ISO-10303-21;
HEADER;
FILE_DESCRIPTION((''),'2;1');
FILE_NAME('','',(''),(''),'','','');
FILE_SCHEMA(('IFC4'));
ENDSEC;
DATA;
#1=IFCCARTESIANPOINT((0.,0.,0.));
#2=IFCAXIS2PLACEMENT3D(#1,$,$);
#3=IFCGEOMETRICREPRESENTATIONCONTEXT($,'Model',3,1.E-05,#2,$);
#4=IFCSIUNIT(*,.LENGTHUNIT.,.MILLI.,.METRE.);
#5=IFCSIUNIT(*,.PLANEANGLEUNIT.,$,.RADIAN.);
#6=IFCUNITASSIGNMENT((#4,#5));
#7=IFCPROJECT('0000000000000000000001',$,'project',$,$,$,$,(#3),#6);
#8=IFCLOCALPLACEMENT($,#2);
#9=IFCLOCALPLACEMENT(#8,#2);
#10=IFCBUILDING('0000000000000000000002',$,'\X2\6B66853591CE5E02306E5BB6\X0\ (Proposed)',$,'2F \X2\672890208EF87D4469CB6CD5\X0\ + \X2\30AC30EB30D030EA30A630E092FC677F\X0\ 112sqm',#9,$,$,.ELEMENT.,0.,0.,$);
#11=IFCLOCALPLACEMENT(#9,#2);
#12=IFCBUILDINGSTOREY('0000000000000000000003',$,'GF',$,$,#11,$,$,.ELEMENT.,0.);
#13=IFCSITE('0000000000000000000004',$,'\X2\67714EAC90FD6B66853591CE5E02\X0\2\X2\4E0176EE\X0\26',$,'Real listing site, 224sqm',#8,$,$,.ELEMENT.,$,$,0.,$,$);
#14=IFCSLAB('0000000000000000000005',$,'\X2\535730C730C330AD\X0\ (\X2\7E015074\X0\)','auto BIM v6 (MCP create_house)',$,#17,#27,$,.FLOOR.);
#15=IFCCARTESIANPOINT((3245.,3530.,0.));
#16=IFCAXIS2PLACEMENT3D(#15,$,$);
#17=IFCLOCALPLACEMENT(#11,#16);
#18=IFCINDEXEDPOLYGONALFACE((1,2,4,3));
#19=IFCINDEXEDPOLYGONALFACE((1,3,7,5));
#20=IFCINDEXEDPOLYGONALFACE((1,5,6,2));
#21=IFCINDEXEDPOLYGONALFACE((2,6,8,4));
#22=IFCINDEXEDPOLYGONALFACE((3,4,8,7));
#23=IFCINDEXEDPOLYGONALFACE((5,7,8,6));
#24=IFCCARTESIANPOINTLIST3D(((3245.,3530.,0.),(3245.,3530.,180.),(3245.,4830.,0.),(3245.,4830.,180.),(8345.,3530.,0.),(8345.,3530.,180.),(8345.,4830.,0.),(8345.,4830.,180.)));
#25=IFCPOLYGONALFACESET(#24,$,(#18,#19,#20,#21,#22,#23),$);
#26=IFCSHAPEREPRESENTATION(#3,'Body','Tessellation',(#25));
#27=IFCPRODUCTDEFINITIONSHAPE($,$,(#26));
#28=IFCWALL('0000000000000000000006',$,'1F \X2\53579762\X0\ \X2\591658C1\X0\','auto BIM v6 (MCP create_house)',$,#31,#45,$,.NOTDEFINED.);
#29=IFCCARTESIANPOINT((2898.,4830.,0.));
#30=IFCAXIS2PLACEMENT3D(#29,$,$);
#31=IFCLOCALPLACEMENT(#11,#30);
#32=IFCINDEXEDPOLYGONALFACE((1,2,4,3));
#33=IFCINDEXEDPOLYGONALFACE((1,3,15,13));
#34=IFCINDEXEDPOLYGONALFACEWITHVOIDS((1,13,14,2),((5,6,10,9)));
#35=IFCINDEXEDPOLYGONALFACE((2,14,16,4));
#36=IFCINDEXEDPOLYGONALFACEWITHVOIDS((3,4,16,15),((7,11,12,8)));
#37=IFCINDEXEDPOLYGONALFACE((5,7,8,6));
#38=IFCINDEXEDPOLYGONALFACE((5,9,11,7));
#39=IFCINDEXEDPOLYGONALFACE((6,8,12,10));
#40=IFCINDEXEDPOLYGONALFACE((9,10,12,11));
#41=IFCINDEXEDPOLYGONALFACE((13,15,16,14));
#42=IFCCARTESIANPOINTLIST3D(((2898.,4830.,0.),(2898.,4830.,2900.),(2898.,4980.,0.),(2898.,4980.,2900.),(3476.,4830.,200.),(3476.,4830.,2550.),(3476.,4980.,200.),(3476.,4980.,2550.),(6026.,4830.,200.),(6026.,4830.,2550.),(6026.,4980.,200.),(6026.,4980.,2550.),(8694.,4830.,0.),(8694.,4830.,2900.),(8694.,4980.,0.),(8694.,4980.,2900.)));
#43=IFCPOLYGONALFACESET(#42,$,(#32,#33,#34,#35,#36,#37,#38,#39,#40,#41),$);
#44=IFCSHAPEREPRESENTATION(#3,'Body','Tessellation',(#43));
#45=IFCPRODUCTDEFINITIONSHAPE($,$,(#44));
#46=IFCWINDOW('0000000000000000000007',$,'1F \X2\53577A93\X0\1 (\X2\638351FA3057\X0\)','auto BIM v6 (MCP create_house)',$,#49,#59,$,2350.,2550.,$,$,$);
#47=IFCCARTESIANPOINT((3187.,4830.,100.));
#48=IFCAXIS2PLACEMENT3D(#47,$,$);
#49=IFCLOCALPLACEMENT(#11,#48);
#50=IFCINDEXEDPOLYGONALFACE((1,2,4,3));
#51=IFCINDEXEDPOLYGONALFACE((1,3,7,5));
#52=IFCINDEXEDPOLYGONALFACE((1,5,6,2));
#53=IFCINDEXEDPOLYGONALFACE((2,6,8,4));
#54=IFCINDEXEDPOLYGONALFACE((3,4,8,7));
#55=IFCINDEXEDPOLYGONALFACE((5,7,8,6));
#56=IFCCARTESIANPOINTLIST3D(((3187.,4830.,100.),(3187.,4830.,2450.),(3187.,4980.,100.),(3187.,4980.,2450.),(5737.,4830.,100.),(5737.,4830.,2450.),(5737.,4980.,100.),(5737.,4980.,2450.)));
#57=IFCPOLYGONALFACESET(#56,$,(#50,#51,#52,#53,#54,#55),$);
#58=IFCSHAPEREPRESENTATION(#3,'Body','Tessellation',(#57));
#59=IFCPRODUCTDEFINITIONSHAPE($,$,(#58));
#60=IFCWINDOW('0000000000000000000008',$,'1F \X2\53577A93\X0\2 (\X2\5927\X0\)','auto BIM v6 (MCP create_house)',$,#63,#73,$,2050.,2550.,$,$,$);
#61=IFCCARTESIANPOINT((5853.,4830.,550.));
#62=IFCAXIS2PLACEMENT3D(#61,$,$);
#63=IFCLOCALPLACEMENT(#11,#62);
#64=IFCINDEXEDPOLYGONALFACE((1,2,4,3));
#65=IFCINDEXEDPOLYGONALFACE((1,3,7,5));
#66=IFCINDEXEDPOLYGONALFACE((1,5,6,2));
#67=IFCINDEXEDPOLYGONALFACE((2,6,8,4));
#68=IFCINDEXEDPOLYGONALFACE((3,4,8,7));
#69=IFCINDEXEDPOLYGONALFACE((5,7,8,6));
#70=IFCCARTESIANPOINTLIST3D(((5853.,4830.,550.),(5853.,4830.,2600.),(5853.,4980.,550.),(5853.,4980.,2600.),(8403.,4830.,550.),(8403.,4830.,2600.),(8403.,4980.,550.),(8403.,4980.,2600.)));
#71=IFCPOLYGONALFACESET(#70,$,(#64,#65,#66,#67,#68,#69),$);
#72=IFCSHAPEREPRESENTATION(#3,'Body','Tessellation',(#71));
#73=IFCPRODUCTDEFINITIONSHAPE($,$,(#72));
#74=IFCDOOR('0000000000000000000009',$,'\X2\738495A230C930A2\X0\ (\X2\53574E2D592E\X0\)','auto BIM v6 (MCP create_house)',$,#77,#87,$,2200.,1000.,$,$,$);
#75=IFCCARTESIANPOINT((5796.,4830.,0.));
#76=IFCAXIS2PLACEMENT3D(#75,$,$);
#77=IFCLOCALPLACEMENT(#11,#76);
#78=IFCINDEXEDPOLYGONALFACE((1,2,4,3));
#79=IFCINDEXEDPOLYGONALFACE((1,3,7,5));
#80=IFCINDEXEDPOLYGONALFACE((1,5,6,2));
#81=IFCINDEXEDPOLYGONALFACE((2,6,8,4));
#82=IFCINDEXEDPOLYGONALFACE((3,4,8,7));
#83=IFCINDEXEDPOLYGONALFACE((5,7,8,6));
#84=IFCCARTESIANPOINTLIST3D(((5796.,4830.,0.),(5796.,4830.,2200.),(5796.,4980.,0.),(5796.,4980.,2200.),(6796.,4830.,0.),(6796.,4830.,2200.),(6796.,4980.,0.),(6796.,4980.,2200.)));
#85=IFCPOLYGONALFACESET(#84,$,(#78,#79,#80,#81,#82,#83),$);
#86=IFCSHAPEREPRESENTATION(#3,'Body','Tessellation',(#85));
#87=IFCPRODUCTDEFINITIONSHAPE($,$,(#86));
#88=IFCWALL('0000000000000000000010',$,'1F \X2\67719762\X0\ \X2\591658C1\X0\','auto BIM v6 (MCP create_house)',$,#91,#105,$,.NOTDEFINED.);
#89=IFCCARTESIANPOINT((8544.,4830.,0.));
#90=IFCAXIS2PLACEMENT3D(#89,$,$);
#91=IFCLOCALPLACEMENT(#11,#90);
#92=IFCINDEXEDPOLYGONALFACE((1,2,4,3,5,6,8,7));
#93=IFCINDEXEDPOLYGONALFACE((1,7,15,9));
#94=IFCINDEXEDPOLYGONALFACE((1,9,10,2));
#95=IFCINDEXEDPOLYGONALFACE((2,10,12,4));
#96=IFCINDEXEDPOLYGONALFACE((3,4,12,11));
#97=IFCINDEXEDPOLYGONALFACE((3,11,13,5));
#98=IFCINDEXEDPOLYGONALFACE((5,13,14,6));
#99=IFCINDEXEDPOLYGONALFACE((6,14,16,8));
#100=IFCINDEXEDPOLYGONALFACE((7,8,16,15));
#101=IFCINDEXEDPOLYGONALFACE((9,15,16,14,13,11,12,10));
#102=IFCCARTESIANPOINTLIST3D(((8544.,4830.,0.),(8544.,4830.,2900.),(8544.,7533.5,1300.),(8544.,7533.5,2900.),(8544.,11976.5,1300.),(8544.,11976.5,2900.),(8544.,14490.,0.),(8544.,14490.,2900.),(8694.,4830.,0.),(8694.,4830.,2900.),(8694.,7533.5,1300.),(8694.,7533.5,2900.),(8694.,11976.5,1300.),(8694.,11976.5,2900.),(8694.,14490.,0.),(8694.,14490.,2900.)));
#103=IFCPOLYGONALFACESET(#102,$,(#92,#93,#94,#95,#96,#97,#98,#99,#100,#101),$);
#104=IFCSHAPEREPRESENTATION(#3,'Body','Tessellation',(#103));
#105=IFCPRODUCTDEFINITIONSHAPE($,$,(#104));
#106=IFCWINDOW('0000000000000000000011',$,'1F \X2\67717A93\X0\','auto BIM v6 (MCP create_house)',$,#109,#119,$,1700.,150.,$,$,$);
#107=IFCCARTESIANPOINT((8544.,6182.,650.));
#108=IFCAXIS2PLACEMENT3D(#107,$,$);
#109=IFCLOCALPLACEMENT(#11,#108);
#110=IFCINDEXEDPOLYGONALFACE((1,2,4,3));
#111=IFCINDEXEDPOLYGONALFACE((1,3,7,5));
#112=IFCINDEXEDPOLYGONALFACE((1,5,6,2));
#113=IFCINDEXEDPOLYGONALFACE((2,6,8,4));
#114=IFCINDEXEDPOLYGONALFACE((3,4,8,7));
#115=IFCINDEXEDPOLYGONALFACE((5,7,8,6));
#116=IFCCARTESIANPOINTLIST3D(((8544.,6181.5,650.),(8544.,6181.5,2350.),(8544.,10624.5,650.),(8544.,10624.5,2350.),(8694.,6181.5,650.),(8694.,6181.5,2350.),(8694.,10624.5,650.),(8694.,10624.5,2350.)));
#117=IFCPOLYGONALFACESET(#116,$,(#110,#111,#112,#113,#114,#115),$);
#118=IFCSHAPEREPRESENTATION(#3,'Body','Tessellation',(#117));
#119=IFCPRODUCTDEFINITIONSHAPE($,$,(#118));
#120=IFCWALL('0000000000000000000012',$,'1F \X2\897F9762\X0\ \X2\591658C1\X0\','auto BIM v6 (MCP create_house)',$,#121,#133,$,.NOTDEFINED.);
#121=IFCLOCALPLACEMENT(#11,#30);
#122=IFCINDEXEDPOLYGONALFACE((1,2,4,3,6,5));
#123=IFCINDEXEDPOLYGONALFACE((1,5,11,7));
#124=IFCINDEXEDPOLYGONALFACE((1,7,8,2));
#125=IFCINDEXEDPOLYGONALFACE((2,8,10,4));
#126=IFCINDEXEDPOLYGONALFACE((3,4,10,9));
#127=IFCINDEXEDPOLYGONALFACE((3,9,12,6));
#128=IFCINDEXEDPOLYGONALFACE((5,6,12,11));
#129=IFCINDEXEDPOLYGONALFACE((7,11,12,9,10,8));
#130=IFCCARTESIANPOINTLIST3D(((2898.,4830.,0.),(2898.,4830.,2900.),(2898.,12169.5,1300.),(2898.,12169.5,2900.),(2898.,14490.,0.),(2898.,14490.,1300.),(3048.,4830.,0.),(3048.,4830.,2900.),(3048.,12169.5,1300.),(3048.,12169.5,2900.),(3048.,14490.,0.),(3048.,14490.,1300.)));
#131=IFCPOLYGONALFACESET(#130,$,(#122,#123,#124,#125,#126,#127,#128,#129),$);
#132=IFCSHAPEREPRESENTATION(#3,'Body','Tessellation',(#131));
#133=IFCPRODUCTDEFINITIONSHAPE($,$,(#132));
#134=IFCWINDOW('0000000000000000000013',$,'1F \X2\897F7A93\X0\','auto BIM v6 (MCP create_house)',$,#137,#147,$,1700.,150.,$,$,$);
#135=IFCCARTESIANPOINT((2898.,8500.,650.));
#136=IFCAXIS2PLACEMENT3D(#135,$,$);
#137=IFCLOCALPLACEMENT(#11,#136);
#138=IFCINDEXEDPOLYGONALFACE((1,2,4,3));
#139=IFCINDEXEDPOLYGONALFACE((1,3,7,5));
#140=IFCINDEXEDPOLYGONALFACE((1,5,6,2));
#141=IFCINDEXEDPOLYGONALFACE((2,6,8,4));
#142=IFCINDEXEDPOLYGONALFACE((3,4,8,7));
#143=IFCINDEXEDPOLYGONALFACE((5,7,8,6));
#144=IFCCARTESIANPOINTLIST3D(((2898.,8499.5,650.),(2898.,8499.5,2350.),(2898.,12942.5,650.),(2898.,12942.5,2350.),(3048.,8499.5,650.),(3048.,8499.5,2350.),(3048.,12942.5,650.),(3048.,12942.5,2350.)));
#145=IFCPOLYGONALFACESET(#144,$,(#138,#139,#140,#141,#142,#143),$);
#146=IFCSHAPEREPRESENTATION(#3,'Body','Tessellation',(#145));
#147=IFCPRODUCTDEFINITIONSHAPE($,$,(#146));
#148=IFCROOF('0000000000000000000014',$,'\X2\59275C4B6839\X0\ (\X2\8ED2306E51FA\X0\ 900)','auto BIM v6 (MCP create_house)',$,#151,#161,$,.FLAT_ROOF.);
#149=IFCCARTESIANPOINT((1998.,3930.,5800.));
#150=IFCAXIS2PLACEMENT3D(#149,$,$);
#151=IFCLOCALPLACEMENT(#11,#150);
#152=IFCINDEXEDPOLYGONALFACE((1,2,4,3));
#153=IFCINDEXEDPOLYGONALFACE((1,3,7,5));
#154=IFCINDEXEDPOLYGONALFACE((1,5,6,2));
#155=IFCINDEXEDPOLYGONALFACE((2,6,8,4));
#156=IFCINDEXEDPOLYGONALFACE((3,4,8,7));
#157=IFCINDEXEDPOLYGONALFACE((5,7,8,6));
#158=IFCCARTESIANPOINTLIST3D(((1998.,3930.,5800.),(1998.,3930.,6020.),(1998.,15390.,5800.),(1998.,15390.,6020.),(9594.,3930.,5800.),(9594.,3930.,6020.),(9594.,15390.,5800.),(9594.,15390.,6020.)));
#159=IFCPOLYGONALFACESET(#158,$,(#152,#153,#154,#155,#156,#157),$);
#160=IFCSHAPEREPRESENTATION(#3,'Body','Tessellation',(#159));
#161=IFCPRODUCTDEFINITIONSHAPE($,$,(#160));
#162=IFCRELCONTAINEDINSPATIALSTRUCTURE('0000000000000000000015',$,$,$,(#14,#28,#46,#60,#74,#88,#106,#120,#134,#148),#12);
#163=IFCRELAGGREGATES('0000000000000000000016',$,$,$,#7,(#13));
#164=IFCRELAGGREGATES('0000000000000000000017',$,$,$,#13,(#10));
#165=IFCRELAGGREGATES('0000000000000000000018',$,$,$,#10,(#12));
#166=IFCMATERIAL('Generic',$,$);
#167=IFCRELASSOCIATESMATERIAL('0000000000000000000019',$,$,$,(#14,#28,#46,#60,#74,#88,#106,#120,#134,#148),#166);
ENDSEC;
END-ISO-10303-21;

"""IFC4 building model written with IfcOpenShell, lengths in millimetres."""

from ifc_helpers import new_model, si_unit, frame, frame_2d, origin, place, context, project, spatial, rectangle, extrude, material, element, fill, save


model = new_model("IFC4")

# Units and contexts
model_context = context("Model", 3, precision=1e-05, world=origin())
ifc_project = project(units=[si_unit("LENGTHUNIT", "METRE", prefix="MILLI"), si_unit("PLANEANGLEUNIT", "RADIAN")], contexts=[model_context])

# Site, building, storey
site_placement = place(None, origin())
site = spatial("IfcSite", under=ifc_project, at=site_placement, Name="東京都武蔵野市2丁目26", ObjectType="Real listing site, 224sqm", CompositionType="ELEMENT", RefElevation=0.0)
building_placement = place(site_placement, origin())
building = spatial("IfcBuilding", under=site, at=building_placement, Name="武蔵野市の家 (Proposed)", ObjectType="2F 木造軸組構法 + ガルバリウム鋼板 112sqm", CompositionType="ELEMENT", ElevationOfRefHeight=0.0, ElevationOfTerrain=0.0)
storey_placement = place(building_placement, origin())
storey = spatial("IfcBuildingStorey", under=building, at=storey_placement, Name="GF", CompositionType="ELEMENT", Elevation=0.0)

# Slab
ifc_material = material(Name="Generic")
slab_1_placement = place(storey_placement, frame((3245.0, 3530.0, 0.0)))
element("IfcSlab", 1, at=slab_1_placement, inside=storey, material=ifc_material, Name="南デッキ (縁側)", Description="auto BIM v6 (MCP create_house)", PredefinedType="FLOOR", context=model_context, shape_type="SweptSolid", body=[
    extrude(rectangle(XDim=5100.0, YDim=1300.0, at=frame_2d((2550.0, 650.0))), frame((3245.0, 3530.0, 0.0)), (0.0, 0.0, 1.0), 180.0),
])

# Wall, openings, windows, door
wall_1_placement = place(storey_placement, frame((2898.0, 4830.0, 0.0)))
wall_1 = element("IfcWall", 2, at=wall_1_placement, inside=storey, material=ifc_material, Name="1F 南面 外壁", Description="auto BIM v6 (MCP create_house)", PredefinedType="NOTDEFINED", context=model_context, shape_type="SweptSolid", body=[
    extrude(rectangle(XDim=5796.0, YDim=150.0, at=frame_2d((2898.0, 75.0))), frame((2898.0, 4830.0, 0.0)), (0.0, 0.0, 1.0), 2900.0),
])
opening_1_placement = place(storey_placement, frame((3187.0, 4830.0, 100.0)))
opening_1 = element("IfcOpeningElement", 3, at=opening_1_placement, cuts=wall_1, PredefinedType="NOTDEFINED", context=model_context, shape_type="SweptSolid", body=[
    extrude(rectangle(XDim=2550.0, YDim=150.0, at=frame_2d((1275.0, 75.0))), frame((3187.0, 4830.0, 100.0)), (0.0, 0.0, 1.0), 2350.0),
])
opening_2_placement = place(storey_placement, frame((5853.0, 4830.0, 550.0)))
opening_2 = element("IfcOpeningElement", 4, at=opening_2_placement, cuts=wall_1, PredefinedType="NOTDEFINED", context=model_context, shape_type="SweptSolid", body=[
    extrude(rectangle(XDim=2550.0, YDim=150.0, at=frame_2d((1275.0, 75.0))), frame((5853.0, 4830.0, 550.0)), (0.0, 0.0, 1.0), 2050.0),
])
opening_3_placement = place(storey_placement, frame((5796.0, 4830.0, 0.0)))
opening_3 = element("IfcOpeningElement", 5, at=opening_3_placement, cuts=wall_1, PredefinedType="NOTDEFINED", context=model_context, shape_type="SweptSolid", body=[
    extrude(rectangle(XDim=1000.0, YDim=150.0, at=frame_2d((500.0, 75.0))), frame((5796.0, 4830.0, 0.0)), (0.0, 0.0, 1.0), 2200.0),
])
window_1_placement = place(storey_placement, frame((3187.0, 4830.0, 100.0)))
window_1 = element("IfcWindow", 6, at=window_1_placement, inside=storey, material=ifc_material, Name="1F 南窓1 (掃出し)", Description="auto BIM v6 (MCP create_house)", OverallHeight=2350.0, OverallWidth=2550.0, context=model_context, shape_type="SweptSolid", body=[
    extrude(rectangle(XDim=2550.0, YDim=150.0, at=frame_2d((1275.0, 75.0))), frame((3187.0, 4830.0, 100.0)), (0.0, 0.0, 1.0), 2350.0),
])
fill(opening_1, window_1)
window_2_placement = place(storey_placement, frame((5853.0, 4830.0, 550.0)))
window_2 = element("IfcWindow", 7, at=window_2_placement, inside=storey, material=ifc_material, Name="1F 南窓2 (大)", Description="auto BIM v6 (MCP create_house)", OverallHeight=2050.0, OverallWidth=2550.0, context=model_context, shape_type="SweptSolid", body=[
    extrude(rectangle(XDim=2550.0, YDim=150.0, at=frame_2d((1275.0, 75.0))), frame((5853.0, 4830.0, 550.0)), (0.0, 0.0, 1.0), 2050.0),
])
fill(opening_2, window_2)
door_placement = place(storey_placement, frame((5796.0, 4830.0, 0.0)))
door = element("IfcDoor", 8, at=door_placement, inside=storey, material=ifc_material, Name="玄関ドア (南中央)", Description="auto BIM v6 (MCP create_house)", OverallHeight=2200.0, OverallWidth=1000.0, context=model_context, shape_type="SweptSolid", body=[
    extrude(rectangle(XDim=1000.0, YDim=150.0, at=frame_2d((500.0, 75.0))), frame((5796.0, 4830.0, 0.0)), (0.0, 0.0, 1.0), 2200.0),
])
fill(opening_3, door)

# Walls, openings, windows
wall_2_placement = place(storey_placement, frame((8544.0, 4830.0, 0.0)))
wall_2 = element("IfcWall", 9, at=wall_2_placement, inside=storey, material=ifc_material, Name="1F 東面 外壁", Description="auto BIM v6 (MCP create_house)", PredefinedType="NOTDEFINED", context=model_context, shape_type="SweptSolid", body=[
    extrude(rectangle(XDim=150.0, YDim=9660.0, at=frame_2d((75.0, 4830.0))), frame((8544.0, 4830.0, 0.0)), (0.0, 0.0, 1.0), 2900.0),
])
opening_4_placement = place(storey_placement, frame((8544.0, 6182.0, 650.0)))
opening_4 = element("IfcOpeningElement", 10, at=opening_4_placement, cuts=wall_2, PredefinedType="NOTDEFINED", context=model_context, shape_type="SweptSolid", body=[
    extrude(rectangle(XDim=150.0, YDim=4443.0, at=frame_2d((75.0, 2221.0))), frame((8544.0, 6182.0, 650.0)), (0.0, 0.0, 1.0), 1700.0),
])
window_3_placement = place(storey_placement, frame((8544.0, 6182.0, 650.0)))
window_3 = element("IfcWindow", 11, at=window_3_placement, inside=storey, material=ifc_material, Name="1F 東窓", Description="auto BIM v6 (MCP create_house)", OverallHeight=1700.0, OverallWidth=150.0, context=model_context, shape_type="SweptSolid", body=[
    extrude(rectangle(XDim=150.0, YDim=4443.0, at=frame_2d((75.0, 2221.0))), frame((8544.0, 6182.0, 650.0)), (0.0, 0.0, 1.0), 1700.0),
])
fill(opening_4, window_3)
wall_3_placement = place(storey_placement, frame((2898.0, 4830.0, 0.0)))
wall_3 = element("IfcWall", 12, at=wall_3_placement, inside=storey, material=ifc_material, Name="1F 西面 外壁", Description="auto BIM v6 (MCP create_house)", PredefinedType="NOTDEFINED", context=model_context, shape_type="SweptSolid", body=[
    extrude(rectangle(XDim=150.0, YDim=9660.0, at=frame_2d((75.0, 4830.0))), frame((2898.0, 4830.0, 0.0)), (0.0, 0.0, 1.0), 2900.0),
])
opening_5_placement = place(storey_placement, frame((2898.0, 8500.0, 650.0)))
opening_5 = element("IfcOpeningElement", 13, at=opening_5_placement, cuts=wall_3, PredefinedType="NOTDEFINED", context=model_context, shape_type="SweptSolid", body=[
    extrude(rectangle(XDim=150.0, YDim=4443.0, at=frame_2d((75.0, 2221.0))), frame((2898.0, 8500.0, 650.0)), (0.0, 0.0, 1.0), 1700.0),
])
window_4_placement = place(storey_placement, frame((2898.0, 8500.0, 650.0)))
window_4 = element("IfcWindow", 14, at=window_4_placement, inside=storey, material=ifc_material, Name="1F 西窓", Description="auto BIM v6 (MCP create_house)", OverallHeight=1700.0, OverallWidth=150.0, context=model_context, shape_type="SweptSolid", body=[
    extrude(rectangle(XDim=150.0, YDim=4443.0, at=frame_2d((75.0, 2221.0))), frame((2898.0, 8500.0, 650.0)), (0.0, 0.0, 1.0), 1700.0),
])
fill(opening_5, window_4)

# Roof
roof_placement = place(storey_placement, frame((1998.0, 3930.0, 5800.0)))
element("IfcRoof", 15, at=roof_placement, inside=storey, material=ifc_material, Name="大屋根 (軒の出 900)", Description="auto BIM v6 (MCP create_house)", PredefinedType="FLAT_ROOF", context=model_context, shape_type="SweptSolid", body=[
    extrude(rectangle(XDim=7596.0, YDim=11460.0, at=frame_2d((3798.0, 5730.0))), frame((1998.0, 3930.0, 5800.0)), (0.0, 0.0, 1.0), 220.0),
])

save(model, "model.ifc")
